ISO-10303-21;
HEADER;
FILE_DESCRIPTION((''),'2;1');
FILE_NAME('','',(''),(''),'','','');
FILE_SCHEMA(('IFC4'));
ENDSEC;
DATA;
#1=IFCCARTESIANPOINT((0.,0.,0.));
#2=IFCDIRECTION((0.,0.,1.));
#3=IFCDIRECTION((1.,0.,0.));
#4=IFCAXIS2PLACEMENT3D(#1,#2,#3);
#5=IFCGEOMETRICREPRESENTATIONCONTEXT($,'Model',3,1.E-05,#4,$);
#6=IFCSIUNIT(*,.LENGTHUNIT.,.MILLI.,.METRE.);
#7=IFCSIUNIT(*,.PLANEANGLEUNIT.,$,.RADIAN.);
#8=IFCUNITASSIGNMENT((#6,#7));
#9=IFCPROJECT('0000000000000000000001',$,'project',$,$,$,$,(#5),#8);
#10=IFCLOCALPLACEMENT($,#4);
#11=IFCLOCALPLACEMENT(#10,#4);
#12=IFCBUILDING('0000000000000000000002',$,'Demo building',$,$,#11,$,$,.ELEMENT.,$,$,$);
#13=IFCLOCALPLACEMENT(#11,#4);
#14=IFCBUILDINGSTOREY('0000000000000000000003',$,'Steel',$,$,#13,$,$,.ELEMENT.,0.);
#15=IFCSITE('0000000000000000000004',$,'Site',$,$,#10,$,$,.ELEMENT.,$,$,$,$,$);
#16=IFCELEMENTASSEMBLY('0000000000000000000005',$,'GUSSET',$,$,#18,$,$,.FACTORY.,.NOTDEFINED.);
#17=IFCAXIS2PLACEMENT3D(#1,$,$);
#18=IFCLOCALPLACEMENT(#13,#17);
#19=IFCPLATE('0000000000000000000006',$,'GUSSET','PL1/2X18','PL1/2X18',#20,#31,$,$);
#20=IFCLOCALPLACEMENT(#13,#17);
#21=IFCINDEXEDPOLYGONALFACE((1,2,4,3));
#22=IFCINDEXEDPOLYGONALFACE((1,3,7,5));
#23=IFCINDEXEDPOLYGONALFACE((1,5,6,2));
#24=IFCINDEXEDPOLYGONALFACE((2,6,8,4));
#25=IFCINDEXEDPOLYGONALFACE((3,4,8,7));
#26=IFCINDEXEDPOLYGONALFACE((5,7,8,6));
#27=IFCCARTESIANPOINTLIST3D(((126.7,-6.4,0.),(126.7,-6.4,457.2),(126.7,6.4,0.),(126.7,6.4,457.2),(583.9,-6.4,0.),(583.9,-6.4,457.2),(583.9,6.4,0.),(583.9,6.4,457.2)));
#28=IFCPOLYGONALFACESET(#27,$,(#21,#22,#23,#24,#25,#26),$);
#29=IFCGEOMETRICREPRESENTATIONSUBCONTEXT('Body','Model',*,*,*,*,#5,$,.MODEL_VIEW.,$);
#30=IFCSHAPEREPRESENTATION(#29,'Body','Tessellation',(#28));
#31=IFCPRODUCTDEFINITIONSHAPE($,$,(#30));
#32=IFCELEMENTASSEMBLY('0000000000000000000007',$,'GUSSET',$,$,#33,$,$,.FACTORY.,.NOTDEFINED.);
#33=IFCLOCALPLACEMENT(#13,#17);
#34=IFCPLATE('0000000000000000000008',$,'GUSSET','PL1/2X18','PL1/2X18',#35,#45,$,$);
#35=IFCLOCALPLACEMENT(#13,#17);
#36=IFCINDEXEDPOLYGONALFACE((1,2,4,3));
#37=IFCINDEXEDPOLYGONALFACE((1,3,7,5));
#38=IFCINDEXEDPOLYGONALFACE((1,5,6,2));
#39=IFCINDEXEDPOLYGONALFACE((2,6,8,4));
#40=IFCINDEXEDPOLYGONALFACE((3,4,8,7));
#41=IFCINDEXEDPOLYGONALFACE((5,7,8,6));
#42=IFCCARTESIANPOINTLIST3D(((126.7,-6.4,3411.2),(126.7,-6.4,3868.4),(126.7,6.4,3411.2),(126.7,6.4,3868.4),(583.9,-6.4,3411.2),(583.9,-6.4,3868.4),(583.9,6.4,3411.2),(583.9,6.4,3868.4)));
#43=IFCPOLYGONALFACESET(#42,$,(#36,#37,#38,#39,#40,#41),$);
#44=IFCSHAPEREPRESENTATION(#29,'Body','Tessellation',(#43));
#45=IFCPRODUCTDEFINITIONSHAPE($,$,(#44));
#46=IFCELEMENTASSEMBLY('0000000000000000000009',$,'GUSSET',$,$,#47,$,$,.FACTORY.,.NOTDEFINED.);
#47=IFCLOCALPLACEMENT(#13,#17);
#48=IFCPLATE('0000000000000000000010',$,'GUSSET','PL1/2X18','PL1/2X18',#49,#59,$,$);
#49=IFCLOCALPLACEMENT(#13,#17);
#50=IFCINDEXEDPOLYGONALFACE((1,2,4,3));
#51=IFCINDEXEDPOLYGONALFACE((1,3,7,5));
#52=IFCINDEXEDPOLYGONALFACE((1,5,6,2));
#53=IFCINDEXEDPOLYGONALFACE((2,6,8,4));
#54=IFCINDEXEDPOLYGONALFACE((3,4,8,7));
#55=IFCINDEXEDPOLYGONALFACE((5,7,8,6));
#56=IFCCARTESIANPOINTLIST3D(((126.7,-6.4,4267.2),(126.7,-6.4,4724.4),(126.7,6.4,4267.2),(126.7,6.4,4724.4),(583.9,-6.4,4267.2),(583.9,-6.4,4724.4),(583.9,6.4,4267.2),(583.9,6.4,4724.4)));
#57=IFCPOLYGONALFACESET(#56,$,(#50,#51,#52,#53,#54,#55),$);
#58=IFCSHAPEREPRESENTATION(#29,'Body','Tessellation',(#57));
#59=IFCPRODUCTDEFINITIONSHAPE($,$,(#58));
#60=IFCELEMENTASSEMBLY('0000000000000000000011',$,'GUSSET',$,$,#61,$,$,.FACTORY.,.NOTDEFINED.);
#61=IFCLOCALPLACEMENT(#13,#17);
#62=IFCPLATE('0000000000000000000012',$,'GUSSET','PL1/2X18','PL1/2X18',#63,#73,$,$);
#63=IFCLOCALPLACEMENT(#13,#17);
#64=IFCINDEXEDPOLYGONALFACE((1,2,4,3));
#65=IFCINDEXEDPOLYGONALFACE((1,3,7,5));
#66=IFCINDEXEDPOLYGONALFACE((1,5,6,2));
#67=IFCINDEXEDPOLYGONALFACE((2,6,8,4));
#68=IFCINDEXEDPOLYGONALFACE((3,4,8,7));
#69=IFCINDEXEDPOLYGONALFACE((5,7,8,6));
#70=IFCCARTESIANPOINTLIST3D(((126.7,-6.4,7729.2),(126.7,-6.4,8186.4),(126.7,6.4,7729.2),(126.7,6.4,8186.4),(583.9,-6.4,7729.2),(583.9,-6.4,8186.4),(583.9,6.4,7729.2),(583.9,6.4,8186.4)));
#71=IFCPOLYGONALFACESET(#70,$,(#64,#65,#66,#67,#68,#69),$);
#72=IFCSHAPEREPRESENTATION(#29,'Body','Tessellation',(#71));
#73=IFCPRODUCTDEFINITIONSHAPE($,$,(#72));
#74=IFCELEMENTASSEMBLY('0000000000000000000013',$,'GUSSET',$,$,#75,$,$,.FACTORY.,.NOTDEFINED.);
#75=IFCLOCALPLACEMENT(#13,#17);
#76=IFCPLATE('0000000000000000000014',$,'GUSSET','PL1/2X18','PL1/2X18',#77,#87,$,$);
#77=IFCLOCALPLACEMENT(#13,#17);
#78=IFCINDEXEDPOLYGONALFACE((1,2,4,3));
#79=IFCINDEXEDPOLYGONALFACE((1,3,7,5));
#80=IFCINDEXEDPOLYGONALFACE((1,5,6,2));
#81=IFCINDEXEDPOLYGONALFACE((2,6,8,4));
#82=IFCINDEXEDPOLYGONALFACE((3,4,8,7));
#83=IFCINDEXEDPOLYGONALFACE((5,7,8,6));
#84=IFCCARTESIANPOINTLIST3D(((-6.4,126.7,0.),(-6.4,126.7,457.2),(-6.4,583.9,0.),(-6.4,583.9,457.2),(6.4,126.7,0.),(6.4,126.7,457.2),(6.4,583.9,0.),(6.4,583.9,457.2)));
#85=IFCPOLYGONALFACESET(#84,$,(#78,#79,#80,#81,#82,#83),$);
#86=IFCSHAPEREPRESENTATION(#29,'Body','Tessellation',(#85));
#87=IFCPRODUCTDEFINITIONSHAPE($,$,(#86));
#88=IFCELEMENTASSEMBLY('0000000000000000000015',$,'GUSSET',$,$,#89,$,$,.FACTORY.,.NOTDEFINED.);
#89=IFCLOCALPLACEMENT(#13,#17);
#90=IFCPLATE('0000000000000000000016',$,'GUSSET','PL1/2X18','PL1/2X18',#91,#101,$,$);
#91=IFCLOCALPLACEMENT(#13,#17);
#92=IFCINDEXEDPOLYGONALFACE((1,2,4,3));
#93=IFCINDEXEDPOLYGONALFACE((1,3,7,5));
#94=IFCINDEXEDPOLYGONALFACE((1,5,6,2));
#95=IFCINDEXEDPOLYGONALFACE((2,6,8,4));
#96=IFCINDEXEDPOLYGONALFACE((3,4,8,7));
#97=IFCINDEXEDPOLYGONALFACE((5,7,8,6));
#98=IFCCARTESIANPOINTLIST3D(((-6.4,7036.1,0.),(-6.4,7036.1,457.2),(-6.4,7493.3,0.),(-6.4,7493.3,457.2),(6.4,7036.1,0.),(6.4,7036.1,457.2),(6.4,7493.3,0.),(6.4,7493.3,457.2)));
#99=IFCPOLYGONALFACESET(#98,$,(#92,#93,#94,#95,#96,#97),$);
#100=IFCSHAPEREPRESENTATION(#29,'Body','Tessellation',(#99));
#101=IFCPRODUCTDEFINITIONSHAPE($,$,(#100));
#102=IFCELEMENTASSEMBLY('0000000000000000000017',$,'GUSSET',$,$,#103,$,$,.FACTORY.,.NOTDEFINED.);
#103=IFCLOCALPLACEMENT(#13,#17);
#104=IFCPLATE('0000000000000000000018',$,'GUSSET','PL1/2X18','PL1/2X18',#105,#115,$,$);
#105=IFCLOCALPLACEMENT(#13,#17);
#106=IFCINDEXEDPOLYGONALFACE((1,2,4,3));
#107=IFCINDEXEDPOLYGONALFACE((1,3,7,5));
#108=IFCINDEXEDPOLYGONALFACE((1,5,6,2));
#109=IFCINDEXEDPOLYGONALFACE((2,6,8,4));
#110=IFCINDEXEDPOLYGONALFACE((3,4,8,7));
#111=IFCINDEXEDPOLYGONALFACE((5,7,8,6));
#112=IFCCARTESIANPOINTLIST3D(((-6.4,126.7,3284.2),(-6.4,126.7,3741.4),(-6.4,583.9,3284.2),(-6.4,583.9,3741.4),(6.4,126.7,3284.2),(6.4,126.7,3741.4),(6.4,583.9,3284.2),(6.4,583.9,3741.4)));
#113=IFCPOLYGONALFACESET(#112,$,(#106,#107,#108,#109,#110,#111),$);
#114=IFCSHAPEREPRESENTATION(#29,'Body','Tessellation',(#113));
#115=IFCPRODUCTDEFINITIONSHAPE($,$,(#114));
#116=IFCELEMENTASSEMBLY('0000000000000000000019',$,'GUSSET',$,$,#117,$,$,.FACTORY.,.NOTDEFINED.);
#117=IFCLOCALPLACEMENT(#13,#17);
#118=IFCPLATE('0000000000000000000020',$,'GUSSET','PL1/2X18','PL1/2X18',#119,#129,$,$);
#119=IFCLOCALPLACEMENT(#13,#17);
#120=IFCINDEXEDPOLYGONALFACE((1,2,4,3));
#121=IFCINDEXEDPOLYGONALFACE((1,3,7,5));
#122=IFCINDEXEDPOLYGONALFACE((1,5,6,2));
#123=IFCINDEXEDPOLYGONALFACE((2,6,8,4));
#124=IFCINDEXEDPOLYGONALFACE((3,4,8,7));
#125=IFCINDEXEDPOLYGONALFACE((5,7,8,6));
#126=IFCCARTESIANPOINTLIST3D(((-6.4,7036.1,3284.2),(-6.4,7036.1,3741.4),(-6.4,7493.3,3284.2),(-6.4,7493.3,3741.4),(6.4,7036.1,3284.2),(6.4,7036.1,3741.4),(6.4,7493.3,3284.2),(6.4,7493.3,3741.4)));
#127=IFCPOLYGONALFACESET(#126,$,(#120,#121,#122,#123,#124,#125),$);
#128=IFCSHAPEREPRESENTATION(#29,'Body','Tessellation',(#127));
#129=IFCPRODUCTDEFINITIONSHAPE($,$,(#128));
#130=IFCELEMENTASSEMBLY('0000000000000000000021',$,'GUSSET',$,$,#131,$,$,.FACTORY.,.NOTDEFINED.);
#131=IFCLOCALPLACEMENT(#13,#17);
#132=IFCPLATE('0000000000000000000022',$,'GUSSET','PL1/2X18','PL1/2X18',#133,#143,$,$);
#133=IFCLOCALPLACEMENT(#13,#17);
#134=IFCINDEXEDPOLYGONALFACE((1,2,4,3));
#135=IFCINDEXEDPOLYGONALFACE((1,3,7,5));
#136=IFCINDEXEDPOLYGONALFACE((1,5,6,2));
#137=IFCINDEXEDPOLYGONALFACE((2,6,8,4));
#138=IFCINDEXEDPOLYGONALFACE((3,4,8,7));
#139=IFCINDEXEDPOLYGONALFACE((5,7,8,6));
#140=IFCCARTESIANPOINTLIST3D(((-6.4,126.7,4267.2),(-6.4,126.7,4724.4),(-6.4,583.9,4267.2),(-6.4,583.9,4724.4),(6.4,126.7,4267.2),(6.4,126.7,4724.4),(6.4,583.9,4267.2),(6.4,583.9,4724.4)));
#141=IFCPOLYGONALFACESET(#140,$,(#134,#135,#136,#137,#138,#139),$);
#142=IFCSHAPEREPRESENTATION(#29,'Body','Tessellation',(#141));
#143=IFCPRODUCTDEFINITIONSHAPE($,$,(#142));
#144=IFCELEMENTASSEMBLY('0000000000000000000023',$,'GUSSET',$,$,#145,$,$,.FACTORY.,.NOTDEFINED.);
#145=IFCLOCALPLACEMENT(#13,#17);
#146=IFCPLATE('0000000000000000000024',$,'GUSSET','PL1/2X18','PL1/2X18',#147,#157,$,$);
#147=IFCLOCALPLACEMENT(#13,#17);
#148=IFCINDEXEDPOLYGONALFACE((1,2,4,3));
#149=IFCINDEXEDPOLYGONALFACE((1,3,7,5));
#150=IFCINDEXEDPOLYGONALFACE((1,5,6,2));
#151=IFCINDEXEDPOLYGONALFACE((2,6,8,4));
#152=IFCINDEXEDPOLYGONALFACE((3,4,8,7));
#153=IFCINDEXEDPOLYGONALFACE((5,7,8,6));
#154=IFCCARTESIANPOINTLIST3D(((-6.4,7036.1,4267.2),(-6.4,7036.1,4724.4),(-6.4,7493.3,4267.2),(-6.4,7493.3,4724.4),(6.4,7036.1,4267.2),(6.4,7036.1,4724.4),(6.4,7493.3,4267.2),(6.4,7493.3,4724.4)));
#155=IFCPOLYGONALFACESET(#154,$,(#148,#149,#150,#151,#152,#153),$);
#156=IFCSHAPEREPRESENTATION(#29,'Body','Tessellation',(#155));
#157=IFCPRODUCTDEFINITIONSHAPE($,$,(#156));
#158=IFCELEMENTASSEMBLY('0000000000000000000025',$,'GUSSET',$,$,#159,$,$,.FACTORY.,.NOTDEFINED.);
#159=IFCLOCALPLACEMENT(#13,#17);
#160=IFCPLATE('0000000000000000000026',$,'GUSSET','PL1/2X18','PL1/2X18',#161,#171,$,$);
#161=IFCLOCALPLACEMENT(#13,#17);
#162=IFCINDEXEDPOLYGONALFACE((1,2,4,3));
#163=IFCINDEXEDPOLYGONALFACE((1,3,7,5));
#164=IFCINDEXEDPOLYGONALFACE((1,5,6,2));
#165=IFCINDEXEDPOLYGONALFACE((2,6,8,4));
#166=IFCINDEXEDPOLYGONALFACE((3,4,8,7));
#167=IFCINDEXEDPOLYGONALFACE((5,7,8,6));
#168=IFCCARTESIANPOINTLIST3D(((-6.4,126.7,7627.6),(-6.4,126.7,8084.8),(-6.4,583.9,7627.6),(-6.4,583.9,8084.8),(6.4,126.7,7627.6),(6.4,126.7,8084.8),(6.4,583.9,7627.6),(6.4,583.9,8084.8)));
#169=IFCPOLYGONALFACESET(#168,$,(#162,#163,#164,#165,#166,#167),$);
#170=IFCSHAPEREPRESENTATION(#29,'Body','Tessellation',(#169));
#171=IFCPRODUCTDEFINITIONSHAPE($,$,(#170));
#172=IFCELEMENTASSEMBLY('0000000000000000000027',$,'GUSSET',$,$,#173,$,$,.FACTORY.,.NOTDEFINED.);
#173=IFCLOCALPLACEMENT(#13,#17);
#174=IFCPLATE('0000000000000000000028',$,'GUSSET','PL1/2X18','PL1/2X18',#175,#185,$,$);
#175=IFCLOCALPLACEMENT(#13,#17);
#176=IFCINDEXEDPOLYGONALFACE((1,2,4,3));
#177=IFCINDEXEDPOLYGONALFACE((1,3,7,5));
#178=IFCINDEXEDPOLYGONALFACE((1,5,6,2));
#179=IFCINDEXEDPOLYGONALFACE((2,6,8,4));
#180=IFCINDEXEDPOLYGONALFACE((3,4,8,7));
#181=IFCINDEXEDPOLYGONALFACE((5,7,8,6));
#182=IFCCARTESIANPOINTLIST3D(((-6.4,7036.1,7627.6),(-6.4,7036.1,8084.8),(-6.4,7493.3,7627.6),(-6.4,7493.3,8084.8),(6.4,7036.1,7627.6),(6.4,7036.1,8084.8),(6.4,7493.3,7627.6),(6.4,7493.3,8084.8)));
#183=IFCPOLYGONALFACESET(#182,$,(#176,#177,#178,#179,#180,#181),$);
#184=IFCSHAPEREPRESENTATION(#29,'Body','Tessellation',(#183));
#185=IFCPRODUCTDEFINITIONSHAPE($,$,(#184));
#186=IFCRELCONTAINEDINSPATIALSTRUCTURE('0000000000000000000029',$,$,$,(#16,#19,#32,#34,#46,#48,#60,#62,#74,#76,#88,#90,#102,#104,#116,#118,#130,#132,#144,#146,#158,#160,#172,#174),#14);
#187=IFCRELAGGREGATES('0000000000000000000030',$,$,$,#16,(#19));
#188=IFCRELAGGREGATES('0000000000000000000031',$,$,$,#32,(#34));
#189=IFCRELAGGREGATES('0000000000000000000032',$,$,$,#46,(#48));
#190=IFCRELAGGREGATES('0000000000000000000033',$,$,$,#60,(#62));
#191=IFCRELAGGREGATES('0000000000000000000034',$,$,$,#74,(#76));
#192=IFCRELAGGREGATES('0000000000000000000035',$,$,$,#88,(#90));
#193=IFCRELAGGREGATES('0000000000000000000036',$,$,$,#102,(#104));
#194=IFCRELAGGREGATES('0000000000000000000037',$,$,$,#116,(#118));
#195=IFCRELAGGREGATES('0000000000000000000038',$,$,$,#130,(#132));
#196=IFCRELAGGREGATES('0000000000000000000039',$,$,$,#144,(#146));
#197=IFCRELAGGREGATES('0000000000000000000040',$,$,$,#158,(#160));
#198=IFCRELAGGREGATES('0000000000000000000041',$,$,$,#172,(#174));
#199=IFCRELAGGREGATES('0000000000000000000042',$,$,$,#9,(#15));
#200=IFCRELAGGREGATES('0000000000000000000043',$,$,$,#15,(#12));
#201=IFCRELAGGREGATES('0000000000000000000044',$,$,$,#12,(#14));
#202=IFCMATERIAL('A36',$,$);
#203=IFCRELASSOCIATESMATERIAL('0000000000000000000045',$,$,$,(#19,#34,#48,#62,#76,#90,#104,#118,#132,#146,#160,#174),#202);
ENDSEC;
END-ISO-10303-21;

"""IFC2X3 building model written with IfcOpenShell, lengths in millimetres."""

from ifc_helpers import new_model, si_unit, frame, frame_2d, origin, origin_with_axes, place, context, subcontext, project, spatial, rectangle, extrude, material, element, aggregate, save


model = new_model("IFC2X3")

# Units and contexts
model_context = context("Model", 3, precision=1e-05, world=origin_with_axes())
body_context = subcontext(model_context, "Body", "Model", "MODEL_VIEW")
ifc_project = project(units=[si_unit("LENGTHUNIT", "METRE", prefix="MILLI"), si_unit("PLANEANGLEUNIT", "RADIAN")], contexts=[model_context])

# Site, building, storey
site_placement = place(None, origin_with_axes())
site = spatial("IfcSite", under=ifc_project, at=site_placement, Name="Site", CompositionType="ELEMENT")
building_placement = place(site_placement, origin_with_axes())
building = spatial("IfcBuilding", under=site, at=building_placement, Name="Demo building", CompositionType="ELEMENT")
placement = place(building_placement, origin_with_axes())
storey = spatial("IfcBuildingStorey", under=building, at=placement, Name="Steel", CompositionType="ELEMENT", Elevation=0.0)

# Shared definitions
ifc_material_1 = material(Name="A36")

# Element assemblies, plates
assembly_1 = element("IfcElementAssembly", 1, at=placement, inside=storey, Name="GUSSET", AssemblyPlace="FACTORY", PredefinedType="NOTDEFINED")
plate_1_placement = place(placement, frame((126.7, 6.3, 0.0), z_axis=(0.0, -1.0, 0.0), x_axis=(1.0, 0.0, 0.0)))
plate_1 = element("IfcPlate", 2, at=plate_1_placement, inside=storey, material=ifc_material_1, Name="GUSSET", Description="PL1/2X18", ObjectType="PL1/2X18", context=body_context, shape_type="SweptSolid", body=[
    extrude(rectangle(XDim=457.2, YDim=457.2, at=frame_2d((228.6, 228.6))), origin(), (0.0, 0.0, 1.0), 12.7),
])
aggregate(assembly_1, [plate_1])
assembly_2 = element("IfcElementAssembly", 3, at=placement, inside=storey, Name="GUSSET", AssemblyPlace="FACTORY", PredefinedType="NOTDEFINED")
plate_2_placement = place(placement, frame((126.7, 6.3, 3411.2), z_axis=(0.0, -1.0, 0.0), x_axis=(1.0, 0.0, 0.0)))
plate_2 = element("IfcPlate", 4, at=plate_2_placement, inside=storey, material=ifc_material_1, Name="GUSSET", Description="PL1/2X18", ObjectType="PL1/2X18", context=body_context, shape_type="SweptSolid", body=[
    extrude(rectangle(XDim=457.2, YDim=457.2, at=frame_2d((228.6, 228.6))), origin(), (0.0, 0.0, 1.0), 12.7),
])
aggregate(assembly_2, [plate_2])
assembly_3 = element("IfcElementAssembly", 5, at=placement, inside=storey, Name="GUSSET", AssemblyPlace="FACTORY", PredefinedType="NOTDEFINED")
plate_3_placement = place(placement, frame((126.7, 6.3, 4267.2), z_axis=(0.0, -1.0, 0.0), x_axis=(1.0, 0.0, 0.0)))
plate_3 = element("IfcPlate", 6, at=plate_3_placement, inside=storey, material=ifc_material_1, Name="GUSSET", Description="PL1/2X18", ObjectType="PL1/2X18", context=body_context, shape_type="SweptSolid", body=[
    extrude(rectangle(XDim=457.2, YDim=457.2, at=frame_2d((228.6, 228.6))), origin(), (0.0, 0.0, 1.0), 12.7),
])
aggregate(assembly_3, [plate_3])
assembly_4 = element("IfcElementAssembly", 7, at=placement, inside=storey, Name="GUSSET", AssemblyPlace="FACTORY", PredefinedType="NOTDEFINED")
plate_4_placement = place(placement, frame((126.7, 6.3, 7729.2), z_axis=(0.0, -1.0, 0.0), x_axis=(1.0, 0.0, 0.0)))
plate_4 = element("IfcPlate", 8, at=plate_4_placement, inside=storey, material=ifc_material_1, Name="GUSSET", Description="PL1/2X18", ObjectType="PL1/2X18", context=body_context, shape_type="SweptSolid", body=[
    extrude(rectangle(XDim=457.2, YDim=457.2, at=frame_2d((228.6, 228.6))), origin(), (0.0, 0.0, 1.0), 12.7),
])
aggregate(assembly_4, [plate_4])
assembly_5 = element("IfcElementAssembly", 9, at=placement, inside=storey, Name="GUSSET", AssemblyPlace="FACTORY", PredefinedType="NOTDEFINED")
plate_5_placement = place(placement, frame((-6.3, 126.7, 0.0), z_axis=(1.0, 0.0, 0.0), x_axis=(0.0, 1.0, 0.0)))
plate_5 = element("IfcPlate", 10, at=plate_5_placement, inside=storey, material=ifc_material_1, Name="GUSSET", Description="PL1/2X18", ObjectType="PL1/2X18", context=body_context, shape_type="SweptSolid", body=[
    extrude(rectangle(XDim=457.2, YDim=457.2, at=frame_2d((228.6, 228.6))), origin(), (0.0, 0.0, 1.0), 12.7),
])
aggregate(assembly_5, [plate_5])
assembly_6 = element("IfcElementAssembly", 11, at=placement, inside=storey, Name="GUSSET", AssemblyPlace="FACTORY", PredefinedType="NOTDEFINED")
plate_6_placement = place(placement, frame((-6.3, 7036.1, 0.0), z_axis=(1.0, 0.0, 0.0), x_axis=(0.0, 1.0, 0.0)))
plate_6 = element("IfcPlate", 12, at=plate_6_placement, inside=storey, material=ifc_material_1, Name="GUSSET", Description="PL1/2X18", ObjectType="PL1/2X18", context=body_context, shape_type="SweptSolid", body=[
    extrude(rectangle(XDim=457.2, YDim=457.2, at=frame_2d((228.6, 228.6))), origin(), (0.0, 0.0, 1.0), 12.7),
])
aggregate(assembly_6, [plate_6])
assembly_7 = element("IfcElementAssembly", 13, at=placement, inside=storey, Name="GUSSET", AssemblyPlace="FACTORY", PredefinedType="NOTDEFINED")
plate_7_placement = place(placement, frame((-6.3, 126.7, 3284.2), z_axis=(1.0, 0.0, 0.0), x_axis=(0.0, 1.0, 0.0)))
plate_7 = element("IfcPlate", 14, at=plate_7_placement, inside=storey, material=ifc_material_1, Name="GUSSET", Description="PL1/2X18", ObjectType="PL1/2X18", context=body_context, shape_type="SweptSolid", body=[
    extrude(rectangle(XDim=457.2, YDim=457.2, at=frame_2d((228.6, 228.6))), origin(), (0.0, 0.0, 1.0), 12.7),
])
aggregate(assembly_7, [plate_7])
assembly_8 = element("IfcElementAssembly", 15, at=placement, inside=storey, Name="GUSSET", AssemblyPlace="FACTORY", PredefinedType="NOTDEFINED")
plate_8_placement = place(placement, frame((-6.3, 7036.1, 3284.2), z_axis=(1.0, 0.0, 0.0), x_axis=(0.0, 1.0, 0.0)))
plate_8 = element("IfcPlate", 16, at=plate_8_placement, inside=storey, material=ifc_material_1, Name="GUSSET", Description="PL1/2X18", ObjectType="PL1/2X18", context=body_context, shape_type="SweptSolid", body=[
    extrude(rectangle(XDim=457.2, YDim=457.2, at=frame_2d((228.6, 228.6))), origin(), (0.0, 0.0, 1.0), 12.7),
])
aggregate(assembly_8, [plate_8])
assembly_9 = element("IfcElementAssembly", 17, at=placement, inside=storey, Name="GUSSET", AssemblyPlace="FACTORY", PredefinedType="NOTDEFINED")
plate_9_placement = place(placement, frame((-6.3, 126.7, 4267.2), z_axis=(1.0, 0.0, 0.0), x_axis=(0.0, 1.0, 0.0)))
plate_9 = element("IfcPlate", 18, at=plate_9_placement, inside=storey, material=ifc_material_1, Name="GUSSET", Description="PL1/2X18", ObjectType="PL1/2X18", context=body_context, shape_type="SweptSolid", body=[
    extrude(rectangle(XDim=457.2, YDim=457.2, at=frame_2d((228.6, 228.6))), origin(), (0.0, 0.0, 1.0), 12.7),
])
aggregate(assembly_9, [plate_9])
assembly_10 = element("IfcElementAssembly", 19, at=placement, inside=storey, Name="GUSSET", AssemblyPlace="FACTORY", PredefinedType="NOTDEFINED")
plate_10_placement = place(placement, frame((-6.3, 7036.1, 4267.2), z_axis=(1.0, 0.0, 0.0), x_axis=(0.0, 1.0, 0.0)))
plate_10 = element("IfcPlate", 20, at=plate_10_placement, inside=storey, material=ifc_material_1, Name="GUSSET", Description="PL1/2X18", ObjectType="PL1/2X18", context=body_context, shape_type="SweptSolid", body=[
    extrude(rectangle(XDim=457.2, YDim=457.2, at=frame_2d((228.6, 228.6))), origin(), (0.0, 0.0, 1.0), 12.7),
])
aggregate(assembly_10, [plate_10])
assembly_11 = element("IfcElementAssembly", 21, at=placement, inside=storey, Name="GUSSET", AssemblyPlace="FACTORY", PredefinedType="NOTDEFINED")
plate_11_placement = place(placement, frame((-6.3, 126.7, 7627.6), z_axis=(1.0, 0.0, 0.0), x_axis=(0.0, 1.0, 0.0)))
plate_11 = element("IfcPlate", 22, at=plate_11_placement, inside=storey, material=ifc_material_1, Name="GUSSET", Description="PL1/2X18", ObjectType="PL1/2X18", context=body_context, shape_type="SweptSolid", body=[
    extrude(rectangle(XDim=457.2, YDim=457.2, at=frame_2d((228.6, 228.6))), origin(), (0.0, 0.0, 1.0), 12.7),
])
aggregate(assembly_11, [plate_11])
assembly_12 = element("IfcElementAssembly", 23, at=placement, inside=storey, Name="GUSSET", AssemblyPlace="FACTORY", PredefinedType="NOTDEFINED")
plate_12_placement = place(placement, frame((-6.3, 7036.1, 7627.6), z_axis=(1.0, 0.0, 0.0), x_axis=(0.0, 1.0, 0.0)))
plate_12 = element("IfcPlate", 24, at=plate_12_placement, inside=storey, material=ifc_material_1, Name="GUSSET", Description="PL1/2X18", ObjectType="PL1/2X18", context=body_context, shape_type="SweptSolid", body=[
    extrude(rectangle(XDim=457.2, YDim=457.2, at=frame_2d((228.6, 228.6))), origin(), (0.0, 0.0, 1.0), 12.7),
])
aggregate(assembly_12, [plate_12])

save(model, "model.ifc")
